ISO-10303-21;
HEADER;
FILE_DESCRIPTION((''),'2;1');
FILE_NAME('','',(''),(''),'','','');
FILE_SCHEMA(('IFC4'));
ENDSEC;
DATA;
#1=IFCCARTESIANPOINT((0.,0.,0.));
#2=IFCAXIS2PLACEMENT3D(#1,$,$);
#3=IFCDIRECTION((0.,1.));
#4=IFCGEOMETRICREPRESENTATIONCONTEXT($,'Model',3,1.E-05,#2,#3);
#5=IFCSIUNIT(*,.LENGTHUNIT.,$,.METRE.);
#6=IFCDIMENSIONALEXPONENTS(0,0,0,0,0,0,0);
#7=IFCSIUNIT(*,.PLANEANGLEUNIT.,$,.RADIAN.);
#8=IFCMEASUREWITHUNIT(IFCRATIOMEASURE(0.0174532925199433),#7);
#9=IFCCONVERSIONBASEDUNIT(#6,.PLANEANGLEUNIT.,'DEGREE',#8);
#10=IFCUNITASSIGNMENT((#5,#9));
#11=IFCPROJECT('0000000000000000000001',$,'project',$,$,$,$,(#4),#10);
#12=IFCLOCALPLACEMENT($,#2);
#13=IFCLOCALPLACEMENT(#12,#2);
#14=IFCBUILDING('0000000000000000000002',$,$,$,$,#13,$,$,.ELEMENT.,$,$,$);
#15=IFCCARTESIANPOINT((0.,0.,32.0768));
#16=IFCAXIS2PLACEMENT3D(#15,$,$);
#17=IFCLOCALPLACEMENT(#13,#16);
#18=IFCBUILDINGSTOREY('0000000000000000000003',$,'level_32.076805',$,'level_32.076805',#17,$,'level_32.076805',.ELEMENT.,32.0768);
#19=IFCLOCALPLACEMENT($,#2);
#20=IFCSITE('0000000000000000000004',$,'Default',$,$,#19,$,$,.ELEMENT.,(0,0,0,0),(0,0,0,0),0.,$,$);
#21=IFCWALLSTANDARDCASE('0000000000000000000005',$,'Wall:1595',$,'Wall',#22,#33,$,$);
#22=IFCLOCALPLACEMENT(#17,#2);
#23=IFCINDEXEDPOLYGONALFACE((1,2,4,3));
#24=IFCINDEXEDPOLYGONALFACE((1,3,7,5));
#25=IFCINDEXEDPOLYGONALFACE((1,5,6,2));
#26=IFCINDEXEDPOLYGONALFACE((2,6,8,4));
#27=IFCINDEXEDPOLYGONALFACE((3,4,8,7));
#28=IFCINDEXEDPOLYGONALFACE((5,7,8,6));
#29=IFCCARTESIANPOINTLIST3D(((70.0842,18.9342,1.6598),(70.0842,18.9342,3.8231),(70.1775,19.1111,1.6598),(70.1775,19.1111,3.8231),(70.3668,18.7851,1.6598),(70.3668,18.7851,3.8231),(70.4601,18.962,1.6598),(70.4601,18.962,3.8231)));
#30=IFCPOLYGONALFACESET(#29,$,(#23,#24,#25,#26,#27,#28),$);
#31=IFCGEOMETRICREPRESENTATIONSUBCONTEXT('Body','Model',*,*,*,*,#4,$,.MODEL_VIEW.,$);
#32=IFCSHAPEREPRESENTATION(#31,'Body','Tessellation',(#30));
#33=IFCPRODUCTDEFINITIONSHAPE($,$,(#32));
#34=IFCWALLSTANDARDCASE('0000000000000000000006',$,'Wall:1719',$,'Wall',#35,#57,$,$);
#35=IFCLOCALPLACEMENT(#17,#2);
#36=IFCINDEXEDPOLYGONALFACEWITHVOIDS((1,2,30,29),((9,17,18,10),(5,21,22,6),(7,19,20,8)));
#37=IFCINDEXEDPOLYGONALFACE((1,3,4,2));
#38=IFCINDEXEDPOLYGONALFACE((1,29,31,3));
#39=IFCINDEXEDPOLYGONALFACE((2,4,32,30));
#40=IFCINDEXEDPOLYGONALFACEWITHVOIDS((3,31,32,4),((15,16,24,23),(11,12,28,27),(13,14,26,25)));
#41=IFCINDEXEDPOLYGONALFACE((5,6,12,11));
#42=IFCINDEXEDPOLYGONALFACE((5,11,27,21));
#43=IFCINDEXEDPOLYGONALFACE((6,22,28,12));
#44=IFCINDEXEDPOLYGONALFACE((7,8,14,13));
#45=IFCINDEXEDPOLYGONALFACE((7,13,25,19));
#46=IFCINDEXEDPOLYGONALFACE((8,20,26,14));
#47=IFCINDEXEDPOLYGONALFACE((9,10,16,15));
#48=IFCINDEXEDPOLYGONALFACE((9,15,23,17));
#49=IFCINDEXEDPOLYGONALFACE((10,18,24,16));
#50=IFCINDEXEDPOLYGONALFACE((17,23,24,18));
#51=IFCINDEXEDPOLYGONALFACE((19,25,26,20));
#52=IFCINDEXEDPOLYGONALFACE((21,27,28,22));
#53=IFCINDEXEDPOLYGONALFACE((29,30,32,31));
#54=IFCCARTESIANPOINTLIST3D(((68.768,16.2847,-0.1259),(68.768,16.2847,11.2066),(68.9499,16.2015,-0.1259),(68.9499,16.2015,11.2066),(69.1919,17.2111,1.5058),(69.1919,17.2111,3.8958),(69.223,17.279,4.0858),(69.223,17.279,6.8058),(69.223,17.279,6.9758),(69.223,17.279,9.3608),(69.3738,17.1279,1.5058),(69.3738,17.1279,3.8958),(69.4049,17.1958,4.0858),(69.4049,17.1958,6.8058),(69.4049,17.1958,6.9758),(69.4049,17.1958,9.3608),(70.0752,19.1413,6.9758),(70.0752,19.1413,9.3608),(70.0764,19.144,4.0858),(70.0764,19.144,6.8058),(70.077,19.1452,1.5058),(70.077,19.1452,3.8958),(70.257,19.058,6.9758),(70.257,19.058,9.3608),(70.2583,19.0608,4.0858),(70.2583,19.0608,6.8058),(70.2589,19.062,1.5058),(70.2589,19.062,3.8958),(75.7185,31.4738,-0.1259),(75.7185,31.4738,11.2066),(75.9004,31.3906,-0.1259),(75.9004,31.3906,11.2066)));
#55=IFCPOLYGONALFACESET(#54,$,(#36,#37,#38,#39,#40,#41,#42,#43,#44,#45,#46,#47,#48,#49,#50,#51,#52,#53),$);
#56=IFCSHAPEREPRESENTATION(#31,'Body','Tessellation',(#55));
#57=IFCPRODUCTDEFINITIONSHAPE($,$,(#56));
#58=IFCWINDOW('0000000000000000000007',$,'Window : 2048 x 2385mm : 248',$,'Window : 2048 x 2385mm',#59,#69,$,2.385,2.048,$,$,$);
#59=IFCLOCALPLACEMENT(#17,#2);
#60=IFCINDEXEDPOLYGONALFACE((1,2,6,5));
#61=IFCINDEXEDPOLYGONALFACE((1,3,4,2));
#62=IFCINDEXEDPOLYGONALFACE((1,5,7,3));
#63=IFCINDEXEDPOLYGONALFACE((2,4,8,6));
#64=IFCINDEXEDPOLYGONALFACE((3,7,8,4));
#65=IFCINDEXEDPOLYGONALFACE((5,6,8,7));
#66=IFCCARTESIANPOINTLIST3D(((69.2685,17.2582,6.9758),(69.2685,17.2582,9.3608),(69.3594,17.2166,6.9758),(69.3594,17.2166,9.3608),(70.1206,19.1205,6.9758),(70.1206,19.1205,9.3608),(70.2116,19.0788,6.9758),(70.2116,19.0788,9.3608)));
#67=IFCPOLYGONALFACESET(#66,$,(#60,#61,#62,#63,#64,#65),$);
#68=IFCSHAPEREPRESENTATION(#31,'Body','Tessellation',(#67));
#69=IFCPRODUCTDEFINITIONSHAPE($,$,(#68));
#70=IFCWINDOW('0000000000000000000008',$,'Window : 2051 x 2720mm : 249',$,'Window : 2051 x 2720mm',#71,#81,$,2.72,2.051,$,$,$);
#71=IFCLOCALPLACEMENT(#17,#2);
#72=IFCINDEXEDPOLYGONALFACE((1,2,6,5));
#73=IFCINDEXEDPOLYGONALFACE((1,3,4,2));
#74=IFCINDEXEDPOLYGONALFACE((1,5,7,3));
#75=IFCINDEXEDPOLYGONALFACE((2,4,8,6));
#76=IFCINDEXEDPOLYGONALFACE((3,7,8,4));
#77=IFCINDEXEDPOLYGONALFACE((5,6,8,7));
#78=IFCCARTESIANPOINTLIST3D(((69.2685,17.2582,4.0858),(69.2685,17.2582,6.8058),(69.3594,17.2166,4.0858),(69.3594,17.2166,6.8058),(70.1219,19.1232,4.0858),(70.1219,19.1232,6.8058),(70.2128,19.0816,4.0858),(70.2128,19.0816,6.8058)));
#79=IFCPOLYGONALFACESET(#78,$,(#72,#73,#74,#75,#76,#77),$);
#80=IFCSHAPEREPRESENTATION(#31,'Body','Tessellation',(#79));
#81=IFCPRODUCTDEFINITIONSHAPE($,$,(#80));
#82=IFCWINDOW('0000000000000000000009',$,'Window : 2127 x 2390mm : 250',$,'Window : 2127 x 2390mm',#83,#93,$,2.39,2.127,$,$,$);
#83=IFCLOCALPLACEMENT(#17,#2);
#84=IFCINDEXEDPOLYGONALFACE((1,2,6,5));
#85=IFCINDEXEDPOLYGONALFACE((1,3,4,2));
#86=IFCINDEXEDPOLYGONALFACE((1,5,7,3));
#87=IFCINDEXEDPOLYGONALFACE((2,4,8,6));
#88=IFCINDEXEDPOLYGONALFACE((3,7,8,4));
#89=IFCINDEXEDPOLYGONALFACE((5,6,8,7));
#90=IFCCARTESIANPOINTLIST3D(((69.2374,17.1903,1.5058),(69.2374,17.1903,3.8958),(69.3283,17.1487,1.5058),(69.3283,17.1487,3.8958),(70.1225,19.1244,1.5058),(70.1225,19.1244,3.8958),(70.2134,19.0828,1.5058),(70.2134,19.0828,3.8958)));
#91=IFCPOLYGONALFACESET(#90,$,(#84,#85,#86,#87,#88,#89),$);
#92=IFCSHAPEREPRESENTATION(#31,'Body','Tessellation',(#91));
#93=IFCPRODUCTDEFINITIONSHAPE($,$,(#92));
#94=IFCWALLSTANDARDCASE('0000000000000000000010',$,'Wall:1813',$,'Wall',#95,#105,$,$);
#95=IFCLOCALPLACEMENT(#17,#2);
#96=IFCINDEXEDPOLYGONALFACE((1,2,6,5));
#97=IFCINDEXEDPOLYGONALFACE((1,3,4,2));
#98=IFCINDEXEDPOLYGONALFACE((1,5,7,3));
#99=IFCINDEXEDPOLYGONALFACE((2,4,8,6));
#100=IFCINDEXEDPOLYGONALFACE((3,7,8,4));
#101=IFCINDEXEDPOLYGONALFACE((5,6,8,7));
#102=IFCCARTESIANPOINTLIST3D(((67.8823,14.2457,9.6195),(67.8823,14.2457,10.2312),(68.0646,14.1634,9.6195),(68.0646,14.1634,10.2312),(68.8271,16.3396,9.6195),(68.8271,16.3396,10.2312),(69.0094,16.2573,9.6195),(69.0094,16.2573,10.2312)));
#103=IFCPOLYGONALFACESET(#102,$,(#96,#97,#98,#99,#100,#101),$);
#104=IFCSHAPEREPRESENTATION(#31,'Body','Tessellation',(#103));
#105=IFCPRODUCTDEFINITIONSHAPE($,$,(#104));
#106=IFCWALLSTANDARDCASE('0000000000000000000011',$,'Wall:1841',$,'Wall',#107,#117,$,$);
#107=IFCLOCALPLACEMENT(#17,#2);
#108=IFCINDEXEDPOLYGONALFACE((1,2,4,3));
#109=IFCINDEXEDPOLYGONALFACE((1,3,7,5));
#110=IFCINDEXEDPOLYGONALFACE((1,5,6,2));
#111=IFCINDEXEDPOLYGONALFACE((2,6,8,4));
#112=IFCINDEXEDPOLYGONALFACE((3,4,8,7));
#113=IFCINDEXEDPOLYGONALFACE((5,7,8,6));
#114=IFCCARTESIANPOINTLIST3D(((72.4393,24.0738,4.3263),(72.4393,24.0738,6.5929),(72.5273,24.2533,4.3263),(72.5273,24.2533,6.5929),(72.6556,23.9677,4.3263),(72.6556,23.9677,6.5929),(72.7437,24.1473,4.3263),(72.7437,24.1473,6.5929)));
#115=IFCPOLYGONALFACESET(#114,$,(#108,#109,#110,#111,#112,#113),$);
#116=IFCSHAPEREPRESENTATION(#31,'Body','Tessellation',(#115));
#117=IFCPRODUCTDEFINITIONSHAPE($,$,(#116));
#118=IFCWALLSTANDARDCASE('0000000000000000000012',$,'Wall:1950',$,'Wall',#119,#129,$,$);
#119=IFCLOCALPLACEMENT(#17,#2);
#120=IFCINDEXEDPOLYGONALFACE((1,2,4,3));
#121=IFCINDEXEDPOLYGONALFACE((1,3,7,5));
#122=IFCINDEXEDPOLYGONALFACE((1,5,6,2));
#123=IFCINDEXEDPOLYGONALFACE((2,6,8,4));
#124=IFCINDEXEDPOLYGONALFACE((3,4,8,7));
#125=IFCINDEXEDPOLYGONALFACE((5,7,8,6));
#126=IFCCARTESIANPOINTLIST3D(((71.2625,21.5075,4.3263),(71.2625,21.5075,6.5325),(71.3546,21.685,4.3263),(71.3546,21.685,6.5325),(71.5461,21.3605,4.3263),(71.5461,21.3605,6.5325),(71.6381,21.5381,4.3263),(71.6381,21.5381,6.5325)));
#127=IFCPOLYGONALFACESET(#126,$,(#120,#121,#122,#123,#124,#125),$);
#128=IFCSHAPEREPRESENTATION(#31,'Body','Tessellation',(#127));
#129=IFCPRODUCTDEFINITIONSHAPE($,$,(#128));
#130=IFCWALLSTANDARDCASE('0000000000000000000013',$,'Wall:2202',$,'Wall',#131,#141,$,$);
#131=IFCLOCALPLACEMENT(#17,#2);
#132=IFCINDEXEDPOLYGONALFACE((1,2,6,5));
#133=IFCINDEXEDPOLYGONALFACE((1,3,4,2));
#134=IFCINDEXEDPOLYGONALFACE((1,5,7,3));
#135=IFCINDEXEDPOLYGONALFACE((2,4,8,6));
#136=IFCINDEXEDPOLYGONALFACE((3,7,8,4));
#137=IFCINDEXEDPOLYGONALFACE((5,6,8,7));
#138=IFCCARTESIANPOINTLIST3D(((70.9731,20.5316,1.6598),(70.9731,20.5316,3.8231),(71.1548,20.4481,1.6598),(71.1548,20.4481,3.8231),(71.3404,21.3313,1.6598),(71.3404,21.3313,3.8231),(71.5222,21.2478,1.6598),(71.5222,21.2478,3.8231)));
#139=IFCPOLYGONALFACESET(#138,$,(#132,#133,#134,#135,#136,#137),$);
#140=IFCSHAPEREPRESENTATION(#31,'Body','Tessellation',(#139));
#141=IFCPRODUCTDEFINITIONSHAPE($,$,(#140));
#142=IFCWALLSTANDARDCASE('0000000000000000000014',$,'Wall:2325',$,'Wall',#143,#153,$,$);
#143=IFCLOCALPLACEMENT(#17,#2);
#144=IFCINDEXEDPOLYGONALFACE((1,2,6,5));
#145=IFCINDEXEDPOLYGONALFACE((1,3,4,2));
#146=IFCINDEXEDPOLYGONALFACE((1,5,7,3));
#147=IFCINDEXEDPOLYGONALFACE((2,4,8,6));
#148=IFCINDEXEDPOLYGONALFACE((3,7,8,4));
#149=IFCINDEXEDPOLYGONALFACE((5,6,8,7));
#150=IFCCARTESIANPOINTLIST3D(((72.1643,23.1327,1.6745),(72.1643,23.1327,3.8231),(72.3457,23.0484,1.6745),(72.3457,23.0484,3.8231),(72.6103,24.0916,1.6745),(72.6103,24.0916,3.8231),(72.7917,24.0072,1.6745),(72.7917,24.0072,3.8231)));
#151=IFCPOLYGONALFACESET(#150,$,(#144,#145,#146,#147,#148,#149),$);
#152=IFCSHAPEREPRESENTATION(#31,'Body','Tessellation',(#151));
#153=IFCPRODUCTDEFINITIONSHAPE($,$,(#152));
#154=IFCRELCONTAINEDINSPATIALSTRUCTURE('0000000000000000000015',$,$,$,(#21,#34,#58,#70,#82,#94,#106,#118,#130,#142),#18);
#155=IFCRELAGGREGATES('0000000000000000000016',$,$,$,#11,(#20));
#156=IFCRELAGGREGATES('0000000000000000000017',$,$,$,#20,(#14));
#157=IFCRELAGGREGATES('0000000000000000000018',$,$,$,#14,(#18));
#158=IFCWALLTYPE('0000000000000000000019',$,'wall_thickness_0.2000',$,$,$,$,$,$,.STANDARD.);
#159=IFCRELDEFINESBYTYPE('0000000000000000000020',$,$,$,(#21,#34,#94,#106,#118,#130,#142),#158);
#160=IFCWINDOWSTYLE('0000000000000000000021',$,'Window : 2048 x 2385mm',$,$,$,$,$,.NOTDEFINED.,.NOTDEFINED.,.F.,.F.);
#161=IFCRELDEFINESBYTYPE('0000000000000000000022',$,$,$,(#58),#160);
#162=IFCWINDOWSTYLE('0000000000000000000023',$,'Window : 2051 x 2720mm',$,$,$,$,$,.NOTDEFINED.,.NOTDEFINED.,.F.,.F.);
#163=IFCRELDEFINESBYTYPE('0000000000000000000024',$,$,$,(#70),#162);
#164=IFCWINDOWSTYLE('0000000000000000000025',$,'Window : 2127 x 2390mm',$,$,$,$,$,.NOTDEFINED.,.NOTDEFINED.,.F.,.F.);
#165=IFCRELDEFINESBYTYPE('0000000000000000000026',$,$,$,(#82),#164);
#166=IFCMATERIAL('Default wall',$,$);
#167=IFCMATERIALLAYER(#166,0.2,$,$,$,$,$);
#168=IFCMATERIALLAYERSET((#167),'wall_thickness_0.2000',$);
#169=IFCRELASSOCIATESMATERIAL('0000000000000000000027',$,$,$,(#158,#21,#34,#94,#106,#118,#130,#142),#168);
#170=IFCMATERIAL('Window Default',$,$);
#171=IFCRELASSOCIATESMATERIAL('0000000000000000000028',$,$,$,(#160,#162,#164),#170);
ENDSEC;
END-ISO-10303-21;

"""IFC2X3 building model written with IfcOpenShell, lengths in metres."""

from ifc_helpers import new_model, entity, si_unit, converted_unit, direction, frame, frame_2d, origin, origin_2d_with_axis, place, context, subcontext, project, spatial, polyline, rectangle, outline, extrude, source, transform, mapped, material, layer, layer_set, layer_usage, type_object, type_shapes, element, fill, save


model = new_model("IFC2X3")

# Units and contexts
model_context = context("Model", 3, precision=1e-05, world=origin(), true_north=direction((0.0, 1.0)))
body_context = subcontext(model_context, "Body", "Model", "MODEL_VIEW")
ifc_project = project(units=[si_unit("LENGTHUNIT", "METRE"), converted_unit("PLANEANGLEUNIT", "DEGREE", entity("IfcRatioMeasure", 0.0174532925199433), si_unit("PLANEANGLEUNIT", "RADIAN"), dimensions=[0, 0, 0, 0, 0, 0, 0])], contexts=[model_context])

# Site, building, storey
site_placement = place(None, origin())
site = spatial("IfcSite", under=ifc_project, at=site_placement, Name="Default", CompositionType="ELEMENT", RefLatitude=(0, 0, 0, 0), RefLongitude=(0, 0, 0, 0), RefElevation=0.0)
placement_1 = place(None, origin())
building_placement = place(placement_1, origin())
building = spatial("IfcBuilding", under=site, at=building_placement, CompositionType="ELEMENT")
storey_placement = place(building_placement, frame((0.0, 0.0, 32.0768)))
storey = spatial("IfcBuildingStorey", under=building, at=storey_placement, Name="level_32.076805", ObjectType="level_32.076805", LongName="level_32.076805", CompositionType="ELEMENT", Elevation=32.0768)

# Shared definitions
ifc_material_1 = material(Name="Default wall")
ifc_layer = layer(ifc_material_1, 0.2)
ifc_layer_set = layer_set([ifc_layer], Name="wall_thickness_0.2000")
ifc_layer_usage = layer_usage(ifc_layer_set, "AXIS2", "POSITIVE", -0.1)
wall_type = type_object("IfcWallType", Name="wall_thickness_0.2000", PredefinedType="STANDARD", material=ifc_layer_set)

# Shared definitions
ifc_material_2 = material(Name="Window Default")

# Wall
placement_2 = place(building_placement, frame((0.0, 0.0, 33.7366)))
wall_1_placement = place(placement_2, frame((70.4135, 18.8736, 0.0), z_axis=(0.0, 0.0, 1.0), x_axis=(-0.884532, 0.466479, 0.0)))
element("IfcWallStandardCase", 1, at=wall_1_placement, inside=storey, type_object=wall_type, material=ifc_layer_usage, Name="Wall:1595", ObjectType="Wall", context=body_context, shape_type="SweptSolid", body=[
    extrude(outline(polyline([(0.3195, -0.1), (0.3195, 0.1), (0.0, 0.1), (0.0, -0.1), (0.3195, -0.1)])), origin(), (0.0, 0.0, 1.0), 2.1633),
])

# Wall, openings, windows
placement_3 = place(building_placement, frame((0.0, 0.0, 31.9509)))
wall_2_placement = place(placement_3, frame((68.859, 16.2431, 0.0), z_axis=(0.0, 0.0, 1.0), x_axis=(0.416099, 0.909319, 0.0)))
wall_2 = element("IfcWallStandardCase", 2, at=wall_2_placement, inside=storey, type_object=wall_type, material=ifc_layer_usage, Name="Wall:1719", ObjectType="Wall", context=body_context, shape_type="SweptSolid", body=[
    extrude(outline(polyline([(16.7038, -0.1), (16.7038, 0.1), (0.0, 0.1), (0.0, -0.1), (16.7038, -0.1)])), origin(), (0.0, 0.0, 1.0), 11.3326),
])
opening_1_placement = place(wall_2_placement, frame((1.0934, -0.1, 7.1018)))
opening_1 = element("IfcOpeningElement", 3, at=opening_1_placement, cuts=wall_2, ObjectType="Opening", context=body_context, shape_type="SweptSolid", body=[
    extrude(rectangle(XDim=2.048, YDim=2.385, at=frame_2d((1.1925, 1.024), x_axis=(0.0, 1.0))), frame((0.0, 0.0, 0.0), z_axis=(0.0, 1.0, 0.0), x_axis=(0.0, 0.0, 1.0)), (0.0, 0.0, 1.0), 0.2),
])
opening_2_placement = place(wall_2_placement, frame((1.0934, -0.1, 4.2118)))
opening_2 = element("IfcOpeningElement", 4, at=opening_2_placement, cuts=wall_2, ObjectType="Opening", context=body_context, shape_type="SweptSolid", body=[
    extrude(rectangle(XDim=2.051, YDim=2.72, at=frame_2d((1.36, 1.0255), x_axis=(0.0, 1.0))), frame((0.0, 0.0, 0.0), z_axis=(0.0, 1.0, 0.0), x_axis=(0.0, 0.0, 1.0)), (0.0, 0.0, 1.0), 0.2),
])
opening_3_placement = place(wall_2_placement, frame((1.0188, -0.1, 1.6318)))
opening_3 = element("IfcOpeningElement", 5, at=opening_3_placement, cuts=wall_2, ObjectType="Opening", context=body_context, shape_type="SweptSolid", body=[
    extrude(rectangle(XDim=2.127, YDim=2.39, at=frame_2d((1.195, 1.0635), x_axis=(0.0, 1.0))), frame((0.0, 0.0, 0.0), z_axis=(0.0, 1.0, 0.0), x_axis=(0.0, 0.0, 1.0)), (0.0, 0.0, 1.0), 0.2),
])
window_style_1 = type_object("IfcWindowStyle", Name="Window : 2048 x 2385mm", ConstructionType="NOTDEFINED", OperationType="NOTDEFINED", ParameterTakesPrecedence=False, Sizeable=False, material=ifc_material_2)
shared_shape_1 = source(origin(), body_context, "Body", "SweptSolid", [
    extrude(rectangle(XDim=0.1, YDim=2.048, at=origin_2d_with_axis()), frame((1.024, 0.1, 0.0), z_axis=(0.0, 0.0, 1.0), x_axis=(0.0, 1.0, 0.0)), (0.0, 0.0, 1.0), 2.385),
])
type_shapes(window_style_1, [shared_shape_1])
window_1_placement = place(opening_1_placement, origin())
window_1 = element("IfcWindow", 6, at=window_1_placement, inside=storey, type_object=window_style_1, Name="Window : 2048 x 2385mm : 248", ObjectType="Window : 2048 x 2385mm", OverallHeight=2.385, OverallWidth=2.048, context=body_context, shape_type="MappedRepresentation", body=[
    mapped(shared_shape_1, transform((0.0, 0.0, 0.0), scale=1.0)),
])
fill(opening_1, window_1)
window_style_2 = type_object("IfcWindowStyle", Name="Window : 2051 x 2720mm", ConstructionType="NOTDEFINED", OperationType="NOTDEFINED", ParameterTakesPrecedence=False, Sizeable=False, material=ifc_material_2)
shared_shape_2 = source(origin(), body_context, "Body", "SweptSolid", [
    extrude(rectangle(XDim=0.1, YDim=2.051, at=origin_2d_with_axis()), frame((1.0255, 0.1, 0.0), z_axis=(0.0, 0.0, 1.0), x_axis=(0.0, 1.0, 0.0)), (0.0, 0.0, 1.0), 2.72),
])
type_shapes(window_style_2, [shared_shape_2])
window_2_placement = place(opening_2_placement, origin())
window_2 = element("IfcWindow", 7, at=window_2_placement, inside=storey, type_object=window_style_2, Name="Window : 2051 x 2720mm : 249", ObjectType="Window : 2051 x 2720mm", OverallHeight=2.72, OverallWidth=2.051, context=body_context, shape_type="MappedRepresentation", body=[
    mapped(shared_shape_2, transform((0.0, 0.0, 0.0), scale=1.0)),
])
fill(opening_2, window_2)
window_style_3 = type_object("IfcWindowStyle", Name="Window : 2127 x 2390mm", ConstructionType="NOTDEFINED", OperationType="NOTDEFINED", ParameterTakesPrecedence=False, Sizeable=False, material=ifc_material_2)
shared_shape_3 = source(origin(), body_context, "Body", "SweptSolid", [
    extrude(rectangle(XDim=0.1, YDim=2.127, at=origin_2d_with_axis()), frame((1.0635, 0.1, 0.0), z_axis=(0.0, 0.0, 1.0), x_axis=(0.0, 1.0, 0.0)), (0.0, 0.0, 1.0), 2.39),
])
type_shapes(window_style_3, [shared_shape_3])
window_3_placement = place(opening_3_placement, origin())
window_3 = element("IfcWindow", 8, at=window_3_placement, inside=storey, type_object=window_style_3, Name="Window : 2127 x 2390mm : 250", ObjectType="Window : 2127 x 2390mm", OverallHeight=2.39, OverallWidth=2.127, context=body_context, shape_type="MappedRepresentation", body=[
    mapped(shared_shape_3, transform((0.0, 0.0, 0.0), scale=1.0)),
])
fill(opening_3, window_3)

# Walls
placement_4 = place(building_placement, frame((0.0, 0.0, 41.6963)))
wall_3_placement = place(placement_4, frame((67.9734, 14.2045, 0.0), z_axis=(0.0, 0.0, 1.0), x_axis=(0.411311, 0.911495, 0.0)))
element("IfcWallStandardCase", 9, at=wall_3_placement, inside=storey, type_object=wall_type, material=ifc_layer_usage, Name="Wall:1813", ObjectType="Wall", context=body_context, shape_type="SweptSolid", body=[
    extrude(outline(polyline([(2.2972, -0.1), (2.2972, 0.1), (0.0, 0.1), (0.0, -0.1), (2.2972, -0.1)])), origin(), (0.0, 0.0, 1.0), 0.6117),
])
placement_5 = place(building_placement, frame((0.0, 0.0, 36.4031)))
wall_4_placement = place(placement_5, frame((72.6997, 24.0575, 0.0), z_axis=(0.0, 0.0, 1.0), x_axis=(-0.897886, 0.440227, 0.0)))
element("IfcWallStandardCase", 10, at=wall_4_placement, inside=storey, type_object=wall_type, material=ifc_layer_usage, Name="Wall:1841", ObjectType="Wall", context=body_context, shape_type="SweptSolid", body=[
    extrude(outline(polyline([(0.2409, -0.1), (0.2409, 0.1), (0.0, 0.1), (0.0, -0.1), (0.2409, -0.1)])), origin(), (0.0, 0.0, 1.0), 2.2667),
])
placement_6 = place(building_placement, frame((0.0, 0.0, 36.4031)))
wall_5_placement = place(placement_6, frame((71.3086, 21.5963, 0.0), z_axis=(0.0, 0.0, 1.0), x_axis=(0.887818, -0.460195, 0.0)))
element("IfcWallStandardCase", 11, at=wall_5_placement, inside=storey, type_object=wall_type, material=ifc_layer_usage, Name="Wall:1950", ObjectType="Wall", context=body_context, shape_type="SweptSolid", body=[
    extrude(outline(polyline([(0.3194, -0.1), (0.3194, 0.1), (0.0, 0.1), (0.0, -0.1), (0.3194, -0.1)])), origin(), (0.0, 0.0, 1.0), 2.2062),
])
placement_7 = place(building_placement, frame((0.0, 0.0, 33.7366)))
wall_6_placement = place(placement_7, frame((71.064, 20.4899, 0.0), z_axis=(0.0, 0.0, 1.0), x_axis=(0.417423, 0.908712, 0.0)))
element("IfcWallStandardCase", 12, at=wall_6_placement, inside=storey, type_object=wall_type, material=ifc_layer_usage, Name="Wall:2202", ObjectType="Wall", context=body_context, shape_type="SweptSolid", body=[
    extrude(outline(polyline([(0.88, -0.1), (0.88, 0.1), (0.0, 0.1), (0.0, -0.1), (0.88, -0.1)])), origin(), (0.0, 0.0, 1.0), 2.1633),
])
placement_8 = place(building_placement, frame((0.0, 0.0, 33.7513)))
wall_7_placement = place(placement_8, frame((72.255, 23.0905, 0.0), z_axis=(0.0, 0.0, 1.0), x_axis=(0.42171, 0.906731, 0.0)))
element("IfcWallStandardCase", 13, at=wall_7_placement, inside=storey, type_object=wall_type, material=ifc_layer_usage, Name="Wall:2325", ObjectType="Wall", context=body_context, shape_type="SweptSolid", body=[
    extrude(outline(polyline([(1.0575, -0.1), (1.0575, 0.1), (0.0, 0.1), (0.0, -0.1), (1.0575, -0.1)])), origin(), (0.0, 0.0, 1.0), 2.1486),
])

save(model, "model.ifc")
